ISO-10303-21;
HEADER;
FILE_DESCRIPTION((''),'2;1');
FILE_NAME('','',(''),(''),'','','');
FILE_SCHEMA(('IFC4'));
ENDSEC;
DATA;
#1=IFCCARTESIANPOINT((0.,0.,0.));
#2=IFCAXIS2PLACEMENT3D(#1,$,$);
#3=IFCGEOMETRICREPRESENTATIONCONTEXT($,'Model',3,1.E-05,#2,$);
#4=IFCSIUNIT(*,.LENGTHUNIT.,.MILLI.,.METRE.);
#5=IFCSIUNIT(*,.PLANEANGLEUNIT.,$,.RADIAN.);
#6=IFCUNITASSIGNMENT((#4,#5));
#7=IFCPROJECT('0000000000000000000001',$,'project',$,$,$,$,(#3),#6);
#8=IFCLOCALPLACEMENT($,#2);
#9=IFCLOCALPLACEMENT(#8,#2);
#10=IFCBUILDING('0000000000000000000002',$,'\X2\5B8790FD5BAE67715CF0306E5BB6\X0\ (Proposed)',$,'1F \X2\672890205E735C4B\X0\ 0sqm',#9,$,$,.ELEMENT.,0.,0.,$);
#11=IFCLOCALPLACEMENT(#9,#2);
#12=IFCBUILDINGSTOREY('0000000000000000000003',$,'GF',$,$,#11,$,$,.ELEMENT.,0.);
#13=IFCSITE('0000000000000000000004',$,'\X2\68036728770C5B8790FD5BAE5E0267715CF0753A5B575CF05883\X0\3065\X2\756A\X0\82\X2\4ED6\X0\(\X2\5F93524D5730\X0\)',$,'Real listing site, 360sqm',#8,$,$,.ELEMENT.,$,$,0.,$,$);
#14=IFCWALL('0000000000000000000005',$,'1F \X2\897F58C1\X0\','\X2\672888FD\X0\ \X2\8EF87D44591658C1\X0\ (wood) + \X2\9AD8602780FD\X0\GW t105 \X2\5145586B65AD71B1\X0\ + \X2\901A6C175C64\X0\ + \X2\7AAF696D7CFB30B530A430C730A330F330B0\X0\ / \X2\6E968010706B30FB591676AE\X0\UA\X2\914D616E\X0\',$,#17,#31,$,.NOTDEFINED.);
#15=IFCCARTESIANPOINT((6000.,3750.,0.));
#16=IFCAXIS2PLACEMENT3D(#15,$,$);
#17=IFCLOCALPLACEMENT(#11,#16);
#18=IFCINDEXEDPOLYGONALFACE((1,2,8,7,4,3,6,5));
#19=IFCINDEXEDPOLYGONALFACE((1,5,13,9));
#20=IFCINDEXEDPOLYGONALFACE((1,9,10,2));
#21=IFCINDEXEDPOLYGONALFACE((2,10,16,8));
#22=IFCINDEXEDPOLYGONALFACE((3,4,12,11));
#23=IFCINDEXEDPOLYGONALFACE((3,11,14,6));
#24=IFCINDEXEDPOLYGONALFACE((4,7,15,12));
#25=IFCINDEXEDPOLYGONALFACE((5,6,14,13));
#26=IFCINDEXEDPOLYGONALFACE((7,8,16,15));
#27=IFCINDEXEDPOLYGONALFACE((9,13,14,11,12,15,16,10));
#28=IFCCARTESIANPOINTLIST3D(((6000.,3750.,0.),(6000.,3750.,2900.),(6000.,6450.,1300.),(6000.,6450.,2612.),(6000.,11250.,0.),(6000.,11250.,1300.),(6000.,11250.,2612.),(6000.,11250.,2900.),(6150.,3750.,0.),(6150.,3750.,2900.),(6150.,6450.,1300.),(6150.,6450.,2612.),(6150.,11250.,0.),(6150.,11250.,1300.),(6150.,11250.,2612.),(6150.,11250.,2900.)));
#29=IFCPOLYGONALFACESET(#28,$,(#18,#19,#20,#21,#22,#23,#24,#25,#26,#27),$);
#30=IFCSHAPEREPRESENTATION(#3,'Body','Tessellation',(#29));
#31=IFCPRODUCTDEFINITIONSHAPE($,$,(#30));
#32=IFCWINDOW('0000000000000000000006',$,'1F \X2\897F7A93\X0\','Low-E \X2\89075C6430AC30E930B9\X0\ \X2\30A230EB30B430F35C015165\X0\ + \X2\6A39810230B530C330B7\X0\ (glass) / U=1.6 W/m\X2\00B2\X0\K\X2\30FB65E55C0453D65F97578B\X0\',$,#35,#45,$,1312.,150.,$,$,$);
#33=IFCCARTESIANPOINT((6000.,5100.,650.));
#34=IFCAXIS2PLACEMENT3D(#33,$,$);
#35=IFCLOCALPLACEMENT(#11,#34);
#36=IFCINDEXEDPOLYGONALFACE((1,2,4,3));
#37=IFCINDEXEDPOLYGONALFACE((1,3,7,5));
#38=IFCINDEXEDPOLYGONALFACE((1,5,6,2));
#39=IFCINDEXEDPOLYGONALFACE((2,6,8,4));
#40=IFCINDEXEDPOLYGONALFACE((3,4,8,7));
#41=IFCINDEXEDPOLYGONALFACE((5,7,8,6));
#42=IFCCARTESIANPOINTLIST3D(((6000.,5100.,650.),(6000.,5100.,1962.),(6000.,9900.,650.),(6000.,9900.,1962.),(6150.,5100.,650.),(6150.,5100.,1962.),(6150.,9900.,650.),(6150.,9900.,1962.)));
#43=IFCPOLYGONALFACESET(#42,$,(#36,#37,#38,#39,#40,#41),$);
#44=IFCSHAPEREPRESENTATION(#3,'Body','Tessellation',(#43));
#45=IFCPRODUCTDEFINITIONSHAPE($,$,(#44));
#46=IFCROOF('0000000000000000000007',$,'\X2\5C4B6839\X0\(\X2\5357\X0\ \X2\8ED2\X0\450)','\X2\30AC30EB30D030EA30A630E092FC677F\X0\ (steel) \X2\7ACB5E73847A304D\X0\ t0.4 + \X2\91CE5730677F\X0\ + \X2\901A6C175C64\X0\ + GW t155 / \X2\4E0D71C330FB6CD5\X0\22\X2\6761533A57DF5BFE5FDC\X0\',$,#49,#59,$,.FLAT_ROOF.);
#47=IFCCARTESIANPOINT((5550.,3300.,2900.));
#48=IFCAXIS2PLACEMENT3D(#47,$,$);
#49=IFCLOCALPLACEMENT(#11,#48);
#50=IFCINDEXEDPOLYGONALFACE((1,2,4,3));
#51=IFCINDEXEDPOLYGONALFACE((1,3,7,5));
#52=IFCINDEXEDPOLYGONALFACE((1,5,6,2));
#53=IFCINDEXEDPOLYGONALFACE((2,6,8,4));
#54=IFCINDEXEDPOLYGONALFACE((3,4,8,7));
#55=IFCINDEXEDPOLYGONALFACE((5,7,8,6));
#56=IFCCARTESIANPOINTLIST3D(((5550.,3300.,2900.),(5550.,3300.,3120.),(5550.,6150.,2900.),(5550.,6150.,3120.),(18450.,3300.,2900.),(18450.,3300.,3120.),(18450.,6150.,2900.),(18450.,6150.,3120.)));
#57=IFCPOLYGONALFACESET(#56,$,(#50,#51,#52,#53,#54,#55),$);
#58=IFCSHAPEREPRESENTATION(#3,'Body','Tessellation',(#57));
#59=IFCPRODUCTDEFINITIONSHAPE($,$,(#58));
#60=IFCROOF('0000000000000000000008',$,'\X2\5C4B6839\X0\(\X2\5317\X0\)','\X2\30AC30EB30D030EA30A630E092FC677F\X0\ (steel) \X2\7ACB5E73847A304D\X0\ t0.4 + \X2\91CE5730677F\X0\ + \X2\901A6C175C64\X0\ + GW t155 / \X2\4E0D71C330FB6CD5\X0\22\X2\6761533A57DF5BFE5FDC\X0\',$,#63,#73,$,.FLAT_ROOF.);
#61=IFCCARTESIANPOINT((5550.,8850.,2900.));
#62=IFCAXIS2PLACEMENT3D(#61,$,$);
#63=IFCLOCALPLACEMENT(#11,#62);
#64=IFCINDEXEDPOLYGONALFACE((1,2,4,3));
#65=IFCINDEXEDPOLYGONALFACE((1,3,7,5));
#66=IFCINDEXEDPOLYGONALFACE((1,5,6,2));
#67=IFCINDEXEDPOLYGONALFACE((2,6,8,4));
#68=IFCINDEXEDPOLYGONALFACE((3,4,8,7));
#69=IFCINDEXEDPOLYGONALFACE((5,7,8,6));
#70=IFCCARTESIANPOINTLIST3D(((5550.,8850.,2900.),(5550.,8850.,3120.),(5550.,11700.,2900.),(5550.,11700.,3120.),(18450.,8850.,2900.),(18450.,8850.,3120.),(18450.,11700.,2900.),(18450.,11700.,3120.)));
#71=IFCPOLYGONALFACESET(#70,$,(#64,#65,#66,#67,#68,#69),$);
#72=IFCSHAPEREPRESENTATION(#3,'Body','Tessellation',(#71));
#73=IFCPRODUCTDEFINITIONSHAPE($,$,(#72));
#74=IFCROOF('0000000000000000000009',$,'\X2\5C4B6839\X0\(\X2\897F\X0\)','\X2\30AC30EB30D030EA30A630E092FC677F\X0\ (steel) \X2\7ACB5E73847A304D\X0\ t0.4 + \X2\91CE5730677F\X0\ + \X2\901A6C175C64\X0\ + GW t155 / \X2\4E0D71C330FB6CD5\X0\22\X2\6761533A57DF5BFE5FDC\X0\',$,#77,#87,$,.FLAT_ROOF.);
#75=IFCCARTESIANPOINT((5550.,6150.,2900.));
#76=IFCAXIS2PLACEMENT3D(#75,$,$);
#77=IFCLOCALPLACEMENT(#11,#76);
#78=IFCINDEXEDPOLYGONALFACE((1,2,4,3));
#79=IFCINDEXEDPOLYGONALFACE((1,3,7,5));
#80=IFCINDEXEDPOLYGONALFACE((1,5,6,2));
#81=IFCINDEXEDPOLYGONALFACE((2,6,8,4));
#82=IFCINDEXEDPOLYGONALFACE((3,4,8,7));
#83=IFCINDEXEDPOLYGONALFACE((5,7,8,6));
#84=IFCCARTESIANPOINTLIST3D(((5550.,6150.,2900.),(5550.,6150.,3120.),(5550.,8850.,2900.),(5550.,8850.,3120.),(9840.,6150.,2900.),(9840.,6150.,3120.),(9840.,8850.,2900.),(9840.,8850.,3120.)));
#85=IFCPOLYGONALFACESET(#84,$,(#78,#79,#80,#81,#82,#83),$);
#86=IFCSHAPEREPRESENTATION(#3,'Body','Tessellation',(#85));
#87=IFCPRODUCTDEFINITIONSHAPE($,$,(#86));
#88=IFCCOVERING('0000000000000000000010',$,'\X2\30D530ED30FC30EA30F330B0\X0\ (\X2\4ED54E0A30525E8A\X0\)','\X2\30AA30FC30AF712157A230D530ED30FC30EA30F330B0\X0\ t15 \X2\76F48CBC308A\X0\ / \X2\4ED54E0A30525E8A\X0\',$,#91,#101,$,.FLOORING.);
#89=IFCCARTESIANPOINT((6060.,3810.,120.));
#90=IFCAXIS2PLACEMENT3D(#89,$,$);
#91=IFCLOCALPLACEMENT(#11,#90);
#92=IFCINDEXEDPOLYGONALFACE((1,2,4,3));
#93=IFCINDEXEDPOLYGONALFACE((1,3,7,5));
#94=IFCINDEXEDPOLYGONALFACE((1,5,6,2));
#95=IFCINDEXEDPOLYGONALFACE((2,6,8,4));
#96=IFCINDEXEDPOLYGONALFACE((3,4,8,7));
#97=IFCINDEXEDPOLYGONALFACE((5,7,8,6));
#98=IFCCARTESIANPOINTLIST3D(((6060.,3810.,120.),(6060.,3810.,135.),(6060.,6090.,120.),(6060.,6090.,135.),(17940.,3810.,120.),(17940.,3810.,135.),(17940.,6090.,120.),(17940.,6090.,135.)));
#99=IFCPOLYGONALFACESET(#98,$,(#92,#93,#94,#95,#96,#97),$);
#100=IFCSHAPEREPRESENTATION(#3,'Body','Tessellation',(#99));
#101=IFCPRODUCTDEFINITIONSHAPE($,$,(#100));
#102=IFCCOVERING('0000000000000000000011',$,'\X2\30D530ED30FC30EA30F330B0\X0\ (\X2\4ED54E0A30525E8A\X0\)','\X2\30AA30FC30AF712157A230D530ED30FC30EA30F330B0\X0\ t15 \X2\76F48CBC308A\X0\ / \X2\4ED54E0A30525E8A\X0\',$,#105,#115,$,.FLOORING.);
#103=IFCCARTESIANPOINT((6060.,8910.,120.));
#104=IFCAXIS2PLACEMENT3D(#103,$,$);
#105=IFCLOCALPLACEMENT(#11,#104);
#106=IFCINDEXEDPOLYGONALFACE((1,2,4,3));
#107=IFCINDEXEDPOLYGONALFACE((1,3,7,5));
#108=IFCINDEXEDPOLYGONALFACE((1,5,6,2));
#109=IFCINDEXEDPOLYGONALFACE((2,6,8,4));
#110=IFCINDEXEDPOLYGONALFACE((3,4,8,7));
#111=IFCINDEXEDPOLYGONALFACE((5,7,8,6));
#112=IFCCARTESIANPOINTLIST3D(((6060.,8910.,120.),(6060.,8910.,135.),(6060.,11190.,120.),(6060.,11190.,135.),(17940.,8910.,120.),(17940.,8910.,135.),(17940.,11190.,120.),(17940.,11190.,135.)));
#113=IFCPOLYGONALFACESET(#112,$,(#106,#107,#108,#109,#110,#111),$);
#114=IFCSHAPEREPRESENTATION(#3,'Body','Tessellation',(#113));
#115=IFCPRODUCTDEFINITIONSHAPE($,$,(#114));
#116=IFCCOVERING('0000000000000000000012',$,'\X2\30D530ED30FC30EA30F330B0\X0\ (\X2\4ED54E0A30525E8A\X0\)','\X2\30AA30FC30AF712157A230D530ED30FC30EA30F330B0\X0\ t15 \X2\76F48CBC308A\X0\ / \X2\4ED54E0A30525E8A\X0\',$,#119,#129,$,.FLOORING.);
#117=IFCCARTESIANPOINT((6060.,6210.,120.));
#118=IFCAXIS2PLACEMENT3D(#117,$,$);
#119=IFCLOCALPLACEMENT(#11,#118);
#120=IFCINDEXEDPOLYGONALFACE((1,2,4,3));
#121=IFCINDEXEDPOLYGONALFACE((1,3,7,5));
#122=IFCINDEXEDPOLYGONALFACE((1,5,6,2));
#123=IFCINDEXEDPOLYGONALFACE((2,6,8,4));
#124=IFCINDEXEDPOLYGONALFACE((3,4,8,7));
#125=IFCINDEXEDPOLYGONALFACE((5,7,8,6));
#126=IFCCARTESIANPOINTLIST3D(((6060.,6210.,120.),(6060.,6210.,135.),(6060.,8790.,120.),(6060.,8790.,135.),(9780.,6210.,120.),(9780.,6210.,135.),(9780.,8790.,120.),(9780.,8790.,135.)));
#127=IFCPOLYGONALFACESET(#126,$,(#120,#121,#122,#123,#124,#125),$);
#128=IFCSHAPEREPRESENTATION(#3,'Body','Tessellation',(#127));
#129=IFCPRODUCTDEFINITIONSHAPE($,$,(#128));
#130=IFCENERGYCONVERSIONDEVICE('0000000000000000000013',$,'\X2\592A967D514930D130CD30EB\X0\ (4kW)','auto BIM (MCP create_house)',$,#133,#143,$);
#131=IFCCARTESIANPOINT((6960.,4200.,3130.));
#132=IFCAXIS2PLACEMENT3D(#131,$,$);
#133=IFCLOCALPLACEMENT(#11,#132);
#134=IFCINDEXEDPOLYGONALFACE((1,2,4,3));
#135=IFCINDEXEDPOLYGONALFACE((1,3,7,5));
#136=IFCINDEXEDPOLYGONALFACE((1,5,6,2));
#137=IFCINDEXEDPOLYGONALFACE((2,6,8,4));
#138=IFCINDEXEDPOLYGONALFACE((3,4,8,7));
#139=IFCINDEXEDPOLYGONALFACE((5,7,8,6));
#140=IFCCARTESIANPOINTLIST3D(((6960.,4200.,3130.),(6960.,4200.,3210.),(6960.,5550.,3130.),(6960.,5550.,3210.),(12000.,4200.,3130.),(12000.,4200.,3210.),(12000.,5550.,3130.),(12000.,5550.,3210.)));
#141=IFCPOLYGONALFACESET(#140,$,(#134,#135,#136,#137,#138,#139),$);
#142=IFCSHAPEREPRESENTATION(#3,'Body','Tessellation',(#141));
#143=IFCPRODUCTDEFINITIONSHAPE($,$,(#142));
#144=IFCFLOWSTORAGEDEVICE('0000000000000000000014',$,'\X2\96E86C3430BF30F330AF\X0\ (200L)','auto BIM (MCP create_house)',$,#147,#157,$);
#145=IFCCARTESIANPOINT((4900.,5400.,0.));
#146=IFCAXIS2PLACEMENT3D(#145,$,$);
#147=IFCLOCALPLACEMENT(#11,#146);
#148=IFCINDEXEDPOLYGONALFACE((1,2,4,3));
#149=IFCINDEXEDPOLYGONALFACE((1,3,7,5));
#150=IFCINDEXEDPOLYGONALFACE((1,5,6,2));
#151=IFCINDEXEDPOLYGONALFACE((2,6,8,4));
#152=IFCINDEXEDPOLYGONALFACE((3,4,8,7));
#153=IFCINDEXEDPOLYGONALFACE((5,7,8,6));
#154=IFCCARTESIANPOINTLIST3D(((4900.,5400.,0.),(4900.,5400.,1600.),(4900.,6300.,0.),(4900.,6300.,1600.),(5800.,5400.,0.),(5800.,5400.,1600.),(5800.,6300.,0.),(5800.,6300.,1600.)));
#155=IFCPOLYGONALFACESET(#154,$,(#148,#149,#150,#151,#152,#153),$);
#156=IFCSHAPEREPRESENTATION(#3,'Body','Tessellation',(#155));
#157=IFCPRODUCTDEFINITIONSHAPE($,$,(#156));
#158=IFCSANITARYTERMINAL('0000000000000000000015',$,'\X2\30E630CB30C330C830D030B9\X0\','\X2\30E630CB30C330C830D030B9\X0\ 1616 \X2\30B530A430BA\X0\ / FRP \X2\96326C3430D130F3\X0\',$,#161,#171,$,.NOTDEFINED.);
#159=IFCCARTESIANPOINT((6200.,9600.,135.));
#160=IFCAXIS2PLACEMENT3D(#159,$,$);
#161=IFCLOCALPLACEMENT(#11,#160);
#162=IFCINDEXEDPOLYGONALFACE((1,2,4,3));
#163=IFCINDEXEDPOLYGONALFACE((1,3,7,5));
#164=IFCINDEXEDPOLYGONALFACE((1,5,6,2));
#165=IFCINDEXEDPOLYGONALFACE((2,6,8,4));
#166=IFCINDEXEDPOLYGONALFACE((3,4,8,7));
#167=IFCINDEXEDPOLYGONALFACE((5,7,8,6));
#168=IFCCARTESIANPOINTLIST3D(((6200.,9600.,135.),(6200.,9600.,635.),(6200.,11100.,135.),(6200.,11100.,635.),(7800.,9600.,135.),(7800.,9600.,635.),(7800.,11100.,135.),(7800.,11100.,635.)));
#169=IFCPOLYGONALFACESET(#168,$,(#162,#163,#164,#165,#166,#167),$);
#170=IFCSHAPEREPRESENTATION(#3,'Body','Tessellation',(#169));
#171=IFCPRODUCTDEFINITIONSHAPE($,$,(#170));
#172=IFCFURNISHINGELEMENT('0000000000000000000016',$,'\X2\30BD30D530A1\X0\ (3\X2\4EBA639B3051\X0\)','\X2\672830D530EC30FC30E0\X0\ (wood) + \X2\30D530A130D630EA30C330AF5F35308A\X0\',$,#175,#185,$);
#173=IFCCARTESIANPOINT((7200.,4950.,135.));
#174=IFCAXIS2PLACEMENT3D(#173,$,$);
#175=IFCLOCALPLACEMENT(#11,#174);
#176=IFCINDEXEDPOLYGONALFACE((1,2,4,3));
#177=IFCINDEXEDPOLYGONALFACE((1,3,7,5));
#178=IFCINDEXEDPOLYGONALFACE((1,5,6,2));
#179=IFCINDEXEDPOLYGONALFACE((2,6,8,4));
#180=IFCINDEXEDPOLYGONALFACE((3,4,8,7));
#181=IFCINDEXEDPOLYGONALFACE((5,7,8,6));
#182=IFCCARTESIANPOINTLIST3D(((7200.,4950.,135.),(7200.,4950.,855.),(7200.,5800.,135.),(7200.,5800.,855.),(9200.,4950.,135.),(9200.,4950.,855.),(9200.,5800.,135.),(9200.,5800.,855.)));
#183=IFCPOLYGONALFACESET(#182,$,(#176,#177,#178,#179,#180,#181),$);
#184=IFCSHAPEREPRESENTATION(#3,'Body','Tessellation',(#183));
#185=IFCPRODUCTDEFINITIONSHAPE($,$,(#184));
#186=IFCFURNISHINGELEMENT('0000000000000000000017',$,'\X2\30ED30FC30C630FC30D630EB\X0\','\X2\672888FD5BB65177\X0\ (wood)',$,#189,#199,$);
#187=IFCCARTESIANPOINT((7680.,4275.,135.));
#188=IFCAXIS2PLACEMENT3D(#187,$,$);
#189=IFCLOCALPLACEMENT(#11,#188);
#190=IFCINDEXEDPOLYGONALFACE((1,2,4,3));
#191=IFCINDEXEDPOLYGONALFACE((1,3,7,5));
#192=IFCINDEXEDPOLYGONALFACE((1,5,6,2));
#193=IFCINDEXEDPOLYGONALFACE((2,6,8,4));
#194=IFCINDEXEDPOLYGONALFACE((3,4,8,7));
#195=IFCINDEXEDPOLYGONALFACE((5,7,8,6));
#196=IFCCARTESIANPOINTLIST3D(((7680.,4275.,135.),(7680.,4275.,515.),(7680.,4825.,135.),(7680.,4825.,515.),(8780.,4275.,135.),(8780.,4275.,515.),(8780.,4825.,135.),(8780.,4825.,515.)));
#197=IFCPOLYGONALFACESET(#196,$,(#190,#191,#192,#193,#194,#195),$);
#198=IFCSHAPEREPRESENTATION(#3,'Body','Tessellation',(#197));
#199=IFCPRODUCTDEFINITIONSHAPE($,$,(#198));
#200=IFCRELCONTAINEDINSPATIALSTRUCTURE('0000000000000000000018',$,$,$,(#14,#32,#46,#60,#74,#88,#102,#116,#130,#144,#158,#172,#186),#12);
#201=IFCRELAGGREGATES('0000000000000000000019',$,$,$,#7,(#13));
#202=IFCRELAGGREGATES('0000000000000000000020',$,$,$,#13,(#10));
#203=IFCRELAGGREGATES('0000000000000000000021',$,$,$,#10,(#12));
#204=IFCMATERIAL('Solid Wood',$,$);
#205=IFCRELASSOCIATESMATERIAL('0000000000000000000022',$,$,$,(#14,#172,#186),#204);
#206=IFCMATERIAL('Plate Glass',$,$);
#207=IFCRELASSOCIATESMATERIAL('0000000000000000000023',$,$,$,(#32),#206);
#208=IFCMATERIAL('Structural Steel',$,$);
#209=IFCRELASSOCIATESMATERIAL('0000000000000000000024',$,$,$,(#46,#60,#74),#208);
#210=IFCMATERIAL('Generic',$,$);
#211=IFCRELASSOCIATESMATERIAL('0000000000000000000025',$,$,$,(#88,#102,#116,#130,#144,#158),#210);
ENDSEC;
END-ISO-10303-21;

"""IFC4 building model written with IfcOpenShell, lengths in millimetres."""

from ifc_helpers import new_model, si_unit, frame, frame_2d, origin, place, context, project, spatial, rectangle, extrude, material, element, fill, save


model = new_model("IFC4")

# Units and contexts
model_context = context("Model", 3, precision=1e-05, world=origin())
ifc_project = project(units=[si_unit("LENGTHUNIT", "METRE", prefix="MILLI"), si_unit("PLANEANGLEUNIT", "RADIAN")], contexts=[model_context])

# Site, building, storey
site_placement = place(None, origin())
site = spatial("IfcSite", under=ifc_project, at=site_placement, Name="栃木県宇都宮市東峰町字峰境3065番82他(従前地)", ObjectType="Real listing site, 360sqm", CompositionType="ELEMENT", RefElevation=0.0)
building_placement = place(site_placement, origin())
building = spatial("IfcBuilding", under=site, at=building_placement, Name="宇都宮東峰の家 (Proposed)", ObjectType="1F 木造平屋 0sqm", CompositionType="ELEMENT", ElevationOfRefHeight=0.0, ElevationOfTerrain=0.0)
storey_placement = place(building_placement, origin())
storey = spatial("IfcBuildingStorey", under=building, at=storey_placement, Name="GF", CompositionType="ELEMENT", Elevation=0.0)

# Shared definitions
ifc_material_1 = material(Name="Solid Wood")

# Shared definitions
ifc_material_2 = material(Name="Plate Glass")

# Wall, opening, window
wall_1_placement = place(storey_placement, frame((6000.0, 3750.0, 0.0)))
wall_1 = element("IfcWall", 1, at=wall_1_placement, inside=storey, material=ifc_material_1, Name="1F 西壁", Description="木製 軸組外壁 (wood) + 高性能GW t105 充填断熱 + 通気層 + 窯業系サイディング / 準耐火・外皮UA配慮", PredefinedType="NOTDEFINED", context=model_context, shape_type="SweptSolid", body=[
    extrude(rectangle(XDim=150.0, YDim=7500.0, at=frame_2d((75.0, 3750.0))), frame((6000.0, 3750.0, 0.0)), (0.0, 0.0, 1.0), 2900.0),
])
opening_1_placement = place(storey_placement, frame((6000.0, 5100.0, 650.0)))
opening_1 = element("IfcOpeningElement", 2, at=opening_1_placement, cuts=wall_1, PredefinedType="NOTDEFINED", context=model_context, shape_type="SweptSolid", body=[
    extrude(rectangle(XDim=150.0, YDim=4800.0, at=frame_2d((75.0, 2400.0))), frame((6000.0, 5100.0, 650.0)), (0.0, 0.0, 1.0), 1312.0),
])
window_1_placement = place(storey_placement, frame((6000.0, 5100.0, 650.0)))
window_1 = element("IfcWindow", 3, at=window_1_placement, inside=storey, material=ifc_material_2, Name="1F 西窓", Description="Low-E 複層ガラス アルゴン封入 + 樹脂サッシ (glass) / U=1.6 W/m²K・日射取得型", OverallHeight=1312.0, OverallWidth=150.0, context=model_context, shape_type="SweptSolid", body=[
    extrude(rectangle(XDim=150.0, YDim=4800.0, at=frame_2d((75.0, 2400.0))), frame((6000.0, 5100.0, 650.0)), (0.0, 0.0, 1.0), 1312.0),
])
fill(opening_1, window_1)

# Roofs
ifc_material_3 = material(Name="Structural Steel")
roof_1_placement = place(storey_placement, frame((5550.0, 3300.0, 2900.0)))
element("IfcRoof", 4, at=roof_1_placement, inside=storey, material=ifc_material_3, Name="屋根(南 軒450)", Description="ガルバリウム鋼板 (steel) 立平葺き t0.4 + 野地板 + 通気層 + GW t155 / 不燃・法22条区域対応", PredefinedType="FLAT_ROOF", context=model_context, shape_type="SweptSolid", body=[
    extrude(rectangle(XDim=12900.0, YDim=2850.0, at=frame_2d((6450.0, 1425.0))), frame((5550.0, 3300.0, 2900.0)), (0.0, 0.0, 1.0), 220.0),
])
roof_2_placement = place(storey_placement, frame((5550.0, 8850.0, 2900.0)))
element("IfcRoof", 5, at=roof_2_placement, inside=storey, material=ifc_material_3, Name="屋根(北)", Description="ガルバリウム鋼板 (steel) 立平葺き t0.4 + 野地板 + 通気層 + GW t155 / 不燃・法22条区域対応", PredefinedType="FLAT_ROOF", context=model_context, shape_type="SweptSolid", body=[
    extrude(rectangle(XDim=12900.0, YDim=2850.0, at=frame_2d((6450.0, 1425.0))), frame((5550.0, 8850.0, 2900.0)), (0.0, 0.0, 1.0), 220.0),
])
roof_3_placement = place(storey_placement, frame((5550.0, 6150.0, 2900.0)))
element("IfcRoof", 6, at=roof_3_placement, inside=storey, material=ifc_material_3, Name="屋根(西)", Description="ガルバリウム鋼板 (steel) 立平葺き t0.4 + 野地板 + 通気層 + GW t155 / 不燃・法22条区域対応", PredefinedType="FLAT_ROOF", context=model_context, shape_type="SweptSolid", body=[
    extrude(rectangle(XDim=4290.0, YDim=2700.0, at=frame_2d((2145.0, 1350.0))), frame((5550.0, 6150.0, 2900.0)), (0.0, 0.0, 1.0), 220.0),
])

# Coverings
ifc_material_4 = material(Name="Generic")
covering_1_placement = place(storey_placement, frame((6060.0, 3810.0, 120.0)))
element("IfcCovering", 7, at=covering_1_placement, inside=storey, material=ifc_material_4, Name="フローリング (仕上げ床)", Description="オーク無垢フローリング t15 直貼り / 仕上げ床", PredefinedType="FLOORING", context=model_context, shape_type="SweptSolid", body=[
    extrude(rectangle(XDim=11880.0, YDim=2280.0, at=frame_2d((5940.0, 1140.0))), frame((6060.0, 3810.0, 120.0)), (0.0, 0.0, 1.0), 15.0),
])
covering_2_placement = place(storey_placement, frame((6060.0, 8910.0, 120.0)))
element("IfcCovering", 8, at=covering_2_placement, inside=storey, material=ifc_material_4, Name="フローリング (仕上げ床)", Description="オーク無垢フローリング t15 直貼り / 仕上げ床", PredefinedType="FLOORING", context=model_context, shape_type="SweptSolid", body=[
    extrude(rectangle(XDim=11880.0, YDim=2280.0, at=frame_2d((5940.0, 1140.0))), frame((6060.0, 8910.0, 120.0)), (0.0, 0.0, 1.0), 15.0),
])
covering_3_placement = place(storey_placement, frame((6060.0, 6210.0, 120.0)))
element("IfcCovering", 9, at=covering_3_placement, inside=storey, material=ifc_material_4, Name="フローリング (仕上げ床)", Description="オーク無垢フローリング t15 直貼り / 仕上げ床", PredefinedType="FLOORING", context=model_context, shape_type="SweptSolid", body=[
    extrude(rectangle(XDim=3720.0, YDim=2580.0, at=frame_2d((1860.0, 1290.0))), frame((6060.0, 6210.0, 120.0)), (0.0, 0.0, 1.0), 15.0),
])

# Energy conversion device
energy_conversion_device_placement = place(storey_placement, frame((6960.0, 4200.0, 3130.0)))
element("IfcEnergyConversionDevice", 10, at=energy_conversion_device_placement, inside=storey, material=ifc_material_4, Name="太陽光パネル (4kW)", Description="auto BIM (MCP create_house)", context=model_context, shape_type="SweptSolid", body=[
    extrude(rectangle(XDim=5040.0, YDim=1350.0, at=frame_2d((2520.0, 675.0))), frame((6960.0, 4200.0, 3130.0)), (0.0, 0.0, 1.0), 80.0),
])

# Flow storage device
flow_storage_device_placement = place(storey_placement, frame((4900.0, 5400.0, 0.0)))
element("IfcFlowStorageDevice", 11, at=flow_storage_device_placement, inside=storey, material=ifc_material_4, Name="雨水タンク (200L)", Description="auto BIM (MCP create_house)", context=model_context, shape_type="SweptSolid", body=[
    extrude(rectangle(XDim=900.0, YDim=900.0, at=frame_2d((450.0, 450.0))), frame((4900.0, 5400.0, 0.0)), (0.0, 0.0, 1.0), 1600.0),
])

# Sanitary terminal
sanitary_terminal_placement = place(storey_placement, frame((6200.0, 9600.0, 135.0)))
element("IfcSanitaryTerminal", 12, at=sanitary_terminal_placement, inside=storey, material=ifc_material_4, Name="ユニットバス", Description="ユニットバス 1616 サイズ / FRP 防水パン", PredefinedType="NOTDEFINED", context=model_context, shape_type="SweptSolid", body=[
    extrude(rectangle(XDim=1600.0, YDim=1500.0, at=frame_2d((800.0, 750.0))), frame((6200.0, 9600.0, 135.0)), (0.0, 0.0, 1.0), 500.0),
])

# Furnishing elements
furnishing_1_placement = place(storey_placement, frame((7200.0, 4950.0, 135.0)))
element("IfcFurnishingElement", 13, at=furnishing_1_placement, inside=storey, material=ifc_material_1, Name="ソファ (3人掛け)", Description="木フレーム (wood) + ファブリック張り", context=model_context, shape_type="SweptSolid", body=[
    extrude(rectangle(XDim=2000.0, YDim=850.0, at=frame_2d((1000.0, 425.0))), frame((7200.0, 4950.0, 135.0)), (0.0, 0.0, 1.0), 720.0),
])
furnishing_2_placement = place(storey_placement, frame((7680.0, 4275.0, 135.0)))
element("IfcFurnishingElement", 14, at=furnishing_2_placement, inside=storey, material=ifc_material_1, Name="ローテーブル", Description="木製家具 (wood)", context=model_context, shape_type="SweptSolid", body=[
    extrude(rectangle(XDim=1100.0, YDim=550.0, at=frame_2d((550.0, 275.0))), frame((7680.0, 4275.0, 135.0)), (0.0, 0.0, 1.0), 380.0),
])

save(model, "model.ifc")
